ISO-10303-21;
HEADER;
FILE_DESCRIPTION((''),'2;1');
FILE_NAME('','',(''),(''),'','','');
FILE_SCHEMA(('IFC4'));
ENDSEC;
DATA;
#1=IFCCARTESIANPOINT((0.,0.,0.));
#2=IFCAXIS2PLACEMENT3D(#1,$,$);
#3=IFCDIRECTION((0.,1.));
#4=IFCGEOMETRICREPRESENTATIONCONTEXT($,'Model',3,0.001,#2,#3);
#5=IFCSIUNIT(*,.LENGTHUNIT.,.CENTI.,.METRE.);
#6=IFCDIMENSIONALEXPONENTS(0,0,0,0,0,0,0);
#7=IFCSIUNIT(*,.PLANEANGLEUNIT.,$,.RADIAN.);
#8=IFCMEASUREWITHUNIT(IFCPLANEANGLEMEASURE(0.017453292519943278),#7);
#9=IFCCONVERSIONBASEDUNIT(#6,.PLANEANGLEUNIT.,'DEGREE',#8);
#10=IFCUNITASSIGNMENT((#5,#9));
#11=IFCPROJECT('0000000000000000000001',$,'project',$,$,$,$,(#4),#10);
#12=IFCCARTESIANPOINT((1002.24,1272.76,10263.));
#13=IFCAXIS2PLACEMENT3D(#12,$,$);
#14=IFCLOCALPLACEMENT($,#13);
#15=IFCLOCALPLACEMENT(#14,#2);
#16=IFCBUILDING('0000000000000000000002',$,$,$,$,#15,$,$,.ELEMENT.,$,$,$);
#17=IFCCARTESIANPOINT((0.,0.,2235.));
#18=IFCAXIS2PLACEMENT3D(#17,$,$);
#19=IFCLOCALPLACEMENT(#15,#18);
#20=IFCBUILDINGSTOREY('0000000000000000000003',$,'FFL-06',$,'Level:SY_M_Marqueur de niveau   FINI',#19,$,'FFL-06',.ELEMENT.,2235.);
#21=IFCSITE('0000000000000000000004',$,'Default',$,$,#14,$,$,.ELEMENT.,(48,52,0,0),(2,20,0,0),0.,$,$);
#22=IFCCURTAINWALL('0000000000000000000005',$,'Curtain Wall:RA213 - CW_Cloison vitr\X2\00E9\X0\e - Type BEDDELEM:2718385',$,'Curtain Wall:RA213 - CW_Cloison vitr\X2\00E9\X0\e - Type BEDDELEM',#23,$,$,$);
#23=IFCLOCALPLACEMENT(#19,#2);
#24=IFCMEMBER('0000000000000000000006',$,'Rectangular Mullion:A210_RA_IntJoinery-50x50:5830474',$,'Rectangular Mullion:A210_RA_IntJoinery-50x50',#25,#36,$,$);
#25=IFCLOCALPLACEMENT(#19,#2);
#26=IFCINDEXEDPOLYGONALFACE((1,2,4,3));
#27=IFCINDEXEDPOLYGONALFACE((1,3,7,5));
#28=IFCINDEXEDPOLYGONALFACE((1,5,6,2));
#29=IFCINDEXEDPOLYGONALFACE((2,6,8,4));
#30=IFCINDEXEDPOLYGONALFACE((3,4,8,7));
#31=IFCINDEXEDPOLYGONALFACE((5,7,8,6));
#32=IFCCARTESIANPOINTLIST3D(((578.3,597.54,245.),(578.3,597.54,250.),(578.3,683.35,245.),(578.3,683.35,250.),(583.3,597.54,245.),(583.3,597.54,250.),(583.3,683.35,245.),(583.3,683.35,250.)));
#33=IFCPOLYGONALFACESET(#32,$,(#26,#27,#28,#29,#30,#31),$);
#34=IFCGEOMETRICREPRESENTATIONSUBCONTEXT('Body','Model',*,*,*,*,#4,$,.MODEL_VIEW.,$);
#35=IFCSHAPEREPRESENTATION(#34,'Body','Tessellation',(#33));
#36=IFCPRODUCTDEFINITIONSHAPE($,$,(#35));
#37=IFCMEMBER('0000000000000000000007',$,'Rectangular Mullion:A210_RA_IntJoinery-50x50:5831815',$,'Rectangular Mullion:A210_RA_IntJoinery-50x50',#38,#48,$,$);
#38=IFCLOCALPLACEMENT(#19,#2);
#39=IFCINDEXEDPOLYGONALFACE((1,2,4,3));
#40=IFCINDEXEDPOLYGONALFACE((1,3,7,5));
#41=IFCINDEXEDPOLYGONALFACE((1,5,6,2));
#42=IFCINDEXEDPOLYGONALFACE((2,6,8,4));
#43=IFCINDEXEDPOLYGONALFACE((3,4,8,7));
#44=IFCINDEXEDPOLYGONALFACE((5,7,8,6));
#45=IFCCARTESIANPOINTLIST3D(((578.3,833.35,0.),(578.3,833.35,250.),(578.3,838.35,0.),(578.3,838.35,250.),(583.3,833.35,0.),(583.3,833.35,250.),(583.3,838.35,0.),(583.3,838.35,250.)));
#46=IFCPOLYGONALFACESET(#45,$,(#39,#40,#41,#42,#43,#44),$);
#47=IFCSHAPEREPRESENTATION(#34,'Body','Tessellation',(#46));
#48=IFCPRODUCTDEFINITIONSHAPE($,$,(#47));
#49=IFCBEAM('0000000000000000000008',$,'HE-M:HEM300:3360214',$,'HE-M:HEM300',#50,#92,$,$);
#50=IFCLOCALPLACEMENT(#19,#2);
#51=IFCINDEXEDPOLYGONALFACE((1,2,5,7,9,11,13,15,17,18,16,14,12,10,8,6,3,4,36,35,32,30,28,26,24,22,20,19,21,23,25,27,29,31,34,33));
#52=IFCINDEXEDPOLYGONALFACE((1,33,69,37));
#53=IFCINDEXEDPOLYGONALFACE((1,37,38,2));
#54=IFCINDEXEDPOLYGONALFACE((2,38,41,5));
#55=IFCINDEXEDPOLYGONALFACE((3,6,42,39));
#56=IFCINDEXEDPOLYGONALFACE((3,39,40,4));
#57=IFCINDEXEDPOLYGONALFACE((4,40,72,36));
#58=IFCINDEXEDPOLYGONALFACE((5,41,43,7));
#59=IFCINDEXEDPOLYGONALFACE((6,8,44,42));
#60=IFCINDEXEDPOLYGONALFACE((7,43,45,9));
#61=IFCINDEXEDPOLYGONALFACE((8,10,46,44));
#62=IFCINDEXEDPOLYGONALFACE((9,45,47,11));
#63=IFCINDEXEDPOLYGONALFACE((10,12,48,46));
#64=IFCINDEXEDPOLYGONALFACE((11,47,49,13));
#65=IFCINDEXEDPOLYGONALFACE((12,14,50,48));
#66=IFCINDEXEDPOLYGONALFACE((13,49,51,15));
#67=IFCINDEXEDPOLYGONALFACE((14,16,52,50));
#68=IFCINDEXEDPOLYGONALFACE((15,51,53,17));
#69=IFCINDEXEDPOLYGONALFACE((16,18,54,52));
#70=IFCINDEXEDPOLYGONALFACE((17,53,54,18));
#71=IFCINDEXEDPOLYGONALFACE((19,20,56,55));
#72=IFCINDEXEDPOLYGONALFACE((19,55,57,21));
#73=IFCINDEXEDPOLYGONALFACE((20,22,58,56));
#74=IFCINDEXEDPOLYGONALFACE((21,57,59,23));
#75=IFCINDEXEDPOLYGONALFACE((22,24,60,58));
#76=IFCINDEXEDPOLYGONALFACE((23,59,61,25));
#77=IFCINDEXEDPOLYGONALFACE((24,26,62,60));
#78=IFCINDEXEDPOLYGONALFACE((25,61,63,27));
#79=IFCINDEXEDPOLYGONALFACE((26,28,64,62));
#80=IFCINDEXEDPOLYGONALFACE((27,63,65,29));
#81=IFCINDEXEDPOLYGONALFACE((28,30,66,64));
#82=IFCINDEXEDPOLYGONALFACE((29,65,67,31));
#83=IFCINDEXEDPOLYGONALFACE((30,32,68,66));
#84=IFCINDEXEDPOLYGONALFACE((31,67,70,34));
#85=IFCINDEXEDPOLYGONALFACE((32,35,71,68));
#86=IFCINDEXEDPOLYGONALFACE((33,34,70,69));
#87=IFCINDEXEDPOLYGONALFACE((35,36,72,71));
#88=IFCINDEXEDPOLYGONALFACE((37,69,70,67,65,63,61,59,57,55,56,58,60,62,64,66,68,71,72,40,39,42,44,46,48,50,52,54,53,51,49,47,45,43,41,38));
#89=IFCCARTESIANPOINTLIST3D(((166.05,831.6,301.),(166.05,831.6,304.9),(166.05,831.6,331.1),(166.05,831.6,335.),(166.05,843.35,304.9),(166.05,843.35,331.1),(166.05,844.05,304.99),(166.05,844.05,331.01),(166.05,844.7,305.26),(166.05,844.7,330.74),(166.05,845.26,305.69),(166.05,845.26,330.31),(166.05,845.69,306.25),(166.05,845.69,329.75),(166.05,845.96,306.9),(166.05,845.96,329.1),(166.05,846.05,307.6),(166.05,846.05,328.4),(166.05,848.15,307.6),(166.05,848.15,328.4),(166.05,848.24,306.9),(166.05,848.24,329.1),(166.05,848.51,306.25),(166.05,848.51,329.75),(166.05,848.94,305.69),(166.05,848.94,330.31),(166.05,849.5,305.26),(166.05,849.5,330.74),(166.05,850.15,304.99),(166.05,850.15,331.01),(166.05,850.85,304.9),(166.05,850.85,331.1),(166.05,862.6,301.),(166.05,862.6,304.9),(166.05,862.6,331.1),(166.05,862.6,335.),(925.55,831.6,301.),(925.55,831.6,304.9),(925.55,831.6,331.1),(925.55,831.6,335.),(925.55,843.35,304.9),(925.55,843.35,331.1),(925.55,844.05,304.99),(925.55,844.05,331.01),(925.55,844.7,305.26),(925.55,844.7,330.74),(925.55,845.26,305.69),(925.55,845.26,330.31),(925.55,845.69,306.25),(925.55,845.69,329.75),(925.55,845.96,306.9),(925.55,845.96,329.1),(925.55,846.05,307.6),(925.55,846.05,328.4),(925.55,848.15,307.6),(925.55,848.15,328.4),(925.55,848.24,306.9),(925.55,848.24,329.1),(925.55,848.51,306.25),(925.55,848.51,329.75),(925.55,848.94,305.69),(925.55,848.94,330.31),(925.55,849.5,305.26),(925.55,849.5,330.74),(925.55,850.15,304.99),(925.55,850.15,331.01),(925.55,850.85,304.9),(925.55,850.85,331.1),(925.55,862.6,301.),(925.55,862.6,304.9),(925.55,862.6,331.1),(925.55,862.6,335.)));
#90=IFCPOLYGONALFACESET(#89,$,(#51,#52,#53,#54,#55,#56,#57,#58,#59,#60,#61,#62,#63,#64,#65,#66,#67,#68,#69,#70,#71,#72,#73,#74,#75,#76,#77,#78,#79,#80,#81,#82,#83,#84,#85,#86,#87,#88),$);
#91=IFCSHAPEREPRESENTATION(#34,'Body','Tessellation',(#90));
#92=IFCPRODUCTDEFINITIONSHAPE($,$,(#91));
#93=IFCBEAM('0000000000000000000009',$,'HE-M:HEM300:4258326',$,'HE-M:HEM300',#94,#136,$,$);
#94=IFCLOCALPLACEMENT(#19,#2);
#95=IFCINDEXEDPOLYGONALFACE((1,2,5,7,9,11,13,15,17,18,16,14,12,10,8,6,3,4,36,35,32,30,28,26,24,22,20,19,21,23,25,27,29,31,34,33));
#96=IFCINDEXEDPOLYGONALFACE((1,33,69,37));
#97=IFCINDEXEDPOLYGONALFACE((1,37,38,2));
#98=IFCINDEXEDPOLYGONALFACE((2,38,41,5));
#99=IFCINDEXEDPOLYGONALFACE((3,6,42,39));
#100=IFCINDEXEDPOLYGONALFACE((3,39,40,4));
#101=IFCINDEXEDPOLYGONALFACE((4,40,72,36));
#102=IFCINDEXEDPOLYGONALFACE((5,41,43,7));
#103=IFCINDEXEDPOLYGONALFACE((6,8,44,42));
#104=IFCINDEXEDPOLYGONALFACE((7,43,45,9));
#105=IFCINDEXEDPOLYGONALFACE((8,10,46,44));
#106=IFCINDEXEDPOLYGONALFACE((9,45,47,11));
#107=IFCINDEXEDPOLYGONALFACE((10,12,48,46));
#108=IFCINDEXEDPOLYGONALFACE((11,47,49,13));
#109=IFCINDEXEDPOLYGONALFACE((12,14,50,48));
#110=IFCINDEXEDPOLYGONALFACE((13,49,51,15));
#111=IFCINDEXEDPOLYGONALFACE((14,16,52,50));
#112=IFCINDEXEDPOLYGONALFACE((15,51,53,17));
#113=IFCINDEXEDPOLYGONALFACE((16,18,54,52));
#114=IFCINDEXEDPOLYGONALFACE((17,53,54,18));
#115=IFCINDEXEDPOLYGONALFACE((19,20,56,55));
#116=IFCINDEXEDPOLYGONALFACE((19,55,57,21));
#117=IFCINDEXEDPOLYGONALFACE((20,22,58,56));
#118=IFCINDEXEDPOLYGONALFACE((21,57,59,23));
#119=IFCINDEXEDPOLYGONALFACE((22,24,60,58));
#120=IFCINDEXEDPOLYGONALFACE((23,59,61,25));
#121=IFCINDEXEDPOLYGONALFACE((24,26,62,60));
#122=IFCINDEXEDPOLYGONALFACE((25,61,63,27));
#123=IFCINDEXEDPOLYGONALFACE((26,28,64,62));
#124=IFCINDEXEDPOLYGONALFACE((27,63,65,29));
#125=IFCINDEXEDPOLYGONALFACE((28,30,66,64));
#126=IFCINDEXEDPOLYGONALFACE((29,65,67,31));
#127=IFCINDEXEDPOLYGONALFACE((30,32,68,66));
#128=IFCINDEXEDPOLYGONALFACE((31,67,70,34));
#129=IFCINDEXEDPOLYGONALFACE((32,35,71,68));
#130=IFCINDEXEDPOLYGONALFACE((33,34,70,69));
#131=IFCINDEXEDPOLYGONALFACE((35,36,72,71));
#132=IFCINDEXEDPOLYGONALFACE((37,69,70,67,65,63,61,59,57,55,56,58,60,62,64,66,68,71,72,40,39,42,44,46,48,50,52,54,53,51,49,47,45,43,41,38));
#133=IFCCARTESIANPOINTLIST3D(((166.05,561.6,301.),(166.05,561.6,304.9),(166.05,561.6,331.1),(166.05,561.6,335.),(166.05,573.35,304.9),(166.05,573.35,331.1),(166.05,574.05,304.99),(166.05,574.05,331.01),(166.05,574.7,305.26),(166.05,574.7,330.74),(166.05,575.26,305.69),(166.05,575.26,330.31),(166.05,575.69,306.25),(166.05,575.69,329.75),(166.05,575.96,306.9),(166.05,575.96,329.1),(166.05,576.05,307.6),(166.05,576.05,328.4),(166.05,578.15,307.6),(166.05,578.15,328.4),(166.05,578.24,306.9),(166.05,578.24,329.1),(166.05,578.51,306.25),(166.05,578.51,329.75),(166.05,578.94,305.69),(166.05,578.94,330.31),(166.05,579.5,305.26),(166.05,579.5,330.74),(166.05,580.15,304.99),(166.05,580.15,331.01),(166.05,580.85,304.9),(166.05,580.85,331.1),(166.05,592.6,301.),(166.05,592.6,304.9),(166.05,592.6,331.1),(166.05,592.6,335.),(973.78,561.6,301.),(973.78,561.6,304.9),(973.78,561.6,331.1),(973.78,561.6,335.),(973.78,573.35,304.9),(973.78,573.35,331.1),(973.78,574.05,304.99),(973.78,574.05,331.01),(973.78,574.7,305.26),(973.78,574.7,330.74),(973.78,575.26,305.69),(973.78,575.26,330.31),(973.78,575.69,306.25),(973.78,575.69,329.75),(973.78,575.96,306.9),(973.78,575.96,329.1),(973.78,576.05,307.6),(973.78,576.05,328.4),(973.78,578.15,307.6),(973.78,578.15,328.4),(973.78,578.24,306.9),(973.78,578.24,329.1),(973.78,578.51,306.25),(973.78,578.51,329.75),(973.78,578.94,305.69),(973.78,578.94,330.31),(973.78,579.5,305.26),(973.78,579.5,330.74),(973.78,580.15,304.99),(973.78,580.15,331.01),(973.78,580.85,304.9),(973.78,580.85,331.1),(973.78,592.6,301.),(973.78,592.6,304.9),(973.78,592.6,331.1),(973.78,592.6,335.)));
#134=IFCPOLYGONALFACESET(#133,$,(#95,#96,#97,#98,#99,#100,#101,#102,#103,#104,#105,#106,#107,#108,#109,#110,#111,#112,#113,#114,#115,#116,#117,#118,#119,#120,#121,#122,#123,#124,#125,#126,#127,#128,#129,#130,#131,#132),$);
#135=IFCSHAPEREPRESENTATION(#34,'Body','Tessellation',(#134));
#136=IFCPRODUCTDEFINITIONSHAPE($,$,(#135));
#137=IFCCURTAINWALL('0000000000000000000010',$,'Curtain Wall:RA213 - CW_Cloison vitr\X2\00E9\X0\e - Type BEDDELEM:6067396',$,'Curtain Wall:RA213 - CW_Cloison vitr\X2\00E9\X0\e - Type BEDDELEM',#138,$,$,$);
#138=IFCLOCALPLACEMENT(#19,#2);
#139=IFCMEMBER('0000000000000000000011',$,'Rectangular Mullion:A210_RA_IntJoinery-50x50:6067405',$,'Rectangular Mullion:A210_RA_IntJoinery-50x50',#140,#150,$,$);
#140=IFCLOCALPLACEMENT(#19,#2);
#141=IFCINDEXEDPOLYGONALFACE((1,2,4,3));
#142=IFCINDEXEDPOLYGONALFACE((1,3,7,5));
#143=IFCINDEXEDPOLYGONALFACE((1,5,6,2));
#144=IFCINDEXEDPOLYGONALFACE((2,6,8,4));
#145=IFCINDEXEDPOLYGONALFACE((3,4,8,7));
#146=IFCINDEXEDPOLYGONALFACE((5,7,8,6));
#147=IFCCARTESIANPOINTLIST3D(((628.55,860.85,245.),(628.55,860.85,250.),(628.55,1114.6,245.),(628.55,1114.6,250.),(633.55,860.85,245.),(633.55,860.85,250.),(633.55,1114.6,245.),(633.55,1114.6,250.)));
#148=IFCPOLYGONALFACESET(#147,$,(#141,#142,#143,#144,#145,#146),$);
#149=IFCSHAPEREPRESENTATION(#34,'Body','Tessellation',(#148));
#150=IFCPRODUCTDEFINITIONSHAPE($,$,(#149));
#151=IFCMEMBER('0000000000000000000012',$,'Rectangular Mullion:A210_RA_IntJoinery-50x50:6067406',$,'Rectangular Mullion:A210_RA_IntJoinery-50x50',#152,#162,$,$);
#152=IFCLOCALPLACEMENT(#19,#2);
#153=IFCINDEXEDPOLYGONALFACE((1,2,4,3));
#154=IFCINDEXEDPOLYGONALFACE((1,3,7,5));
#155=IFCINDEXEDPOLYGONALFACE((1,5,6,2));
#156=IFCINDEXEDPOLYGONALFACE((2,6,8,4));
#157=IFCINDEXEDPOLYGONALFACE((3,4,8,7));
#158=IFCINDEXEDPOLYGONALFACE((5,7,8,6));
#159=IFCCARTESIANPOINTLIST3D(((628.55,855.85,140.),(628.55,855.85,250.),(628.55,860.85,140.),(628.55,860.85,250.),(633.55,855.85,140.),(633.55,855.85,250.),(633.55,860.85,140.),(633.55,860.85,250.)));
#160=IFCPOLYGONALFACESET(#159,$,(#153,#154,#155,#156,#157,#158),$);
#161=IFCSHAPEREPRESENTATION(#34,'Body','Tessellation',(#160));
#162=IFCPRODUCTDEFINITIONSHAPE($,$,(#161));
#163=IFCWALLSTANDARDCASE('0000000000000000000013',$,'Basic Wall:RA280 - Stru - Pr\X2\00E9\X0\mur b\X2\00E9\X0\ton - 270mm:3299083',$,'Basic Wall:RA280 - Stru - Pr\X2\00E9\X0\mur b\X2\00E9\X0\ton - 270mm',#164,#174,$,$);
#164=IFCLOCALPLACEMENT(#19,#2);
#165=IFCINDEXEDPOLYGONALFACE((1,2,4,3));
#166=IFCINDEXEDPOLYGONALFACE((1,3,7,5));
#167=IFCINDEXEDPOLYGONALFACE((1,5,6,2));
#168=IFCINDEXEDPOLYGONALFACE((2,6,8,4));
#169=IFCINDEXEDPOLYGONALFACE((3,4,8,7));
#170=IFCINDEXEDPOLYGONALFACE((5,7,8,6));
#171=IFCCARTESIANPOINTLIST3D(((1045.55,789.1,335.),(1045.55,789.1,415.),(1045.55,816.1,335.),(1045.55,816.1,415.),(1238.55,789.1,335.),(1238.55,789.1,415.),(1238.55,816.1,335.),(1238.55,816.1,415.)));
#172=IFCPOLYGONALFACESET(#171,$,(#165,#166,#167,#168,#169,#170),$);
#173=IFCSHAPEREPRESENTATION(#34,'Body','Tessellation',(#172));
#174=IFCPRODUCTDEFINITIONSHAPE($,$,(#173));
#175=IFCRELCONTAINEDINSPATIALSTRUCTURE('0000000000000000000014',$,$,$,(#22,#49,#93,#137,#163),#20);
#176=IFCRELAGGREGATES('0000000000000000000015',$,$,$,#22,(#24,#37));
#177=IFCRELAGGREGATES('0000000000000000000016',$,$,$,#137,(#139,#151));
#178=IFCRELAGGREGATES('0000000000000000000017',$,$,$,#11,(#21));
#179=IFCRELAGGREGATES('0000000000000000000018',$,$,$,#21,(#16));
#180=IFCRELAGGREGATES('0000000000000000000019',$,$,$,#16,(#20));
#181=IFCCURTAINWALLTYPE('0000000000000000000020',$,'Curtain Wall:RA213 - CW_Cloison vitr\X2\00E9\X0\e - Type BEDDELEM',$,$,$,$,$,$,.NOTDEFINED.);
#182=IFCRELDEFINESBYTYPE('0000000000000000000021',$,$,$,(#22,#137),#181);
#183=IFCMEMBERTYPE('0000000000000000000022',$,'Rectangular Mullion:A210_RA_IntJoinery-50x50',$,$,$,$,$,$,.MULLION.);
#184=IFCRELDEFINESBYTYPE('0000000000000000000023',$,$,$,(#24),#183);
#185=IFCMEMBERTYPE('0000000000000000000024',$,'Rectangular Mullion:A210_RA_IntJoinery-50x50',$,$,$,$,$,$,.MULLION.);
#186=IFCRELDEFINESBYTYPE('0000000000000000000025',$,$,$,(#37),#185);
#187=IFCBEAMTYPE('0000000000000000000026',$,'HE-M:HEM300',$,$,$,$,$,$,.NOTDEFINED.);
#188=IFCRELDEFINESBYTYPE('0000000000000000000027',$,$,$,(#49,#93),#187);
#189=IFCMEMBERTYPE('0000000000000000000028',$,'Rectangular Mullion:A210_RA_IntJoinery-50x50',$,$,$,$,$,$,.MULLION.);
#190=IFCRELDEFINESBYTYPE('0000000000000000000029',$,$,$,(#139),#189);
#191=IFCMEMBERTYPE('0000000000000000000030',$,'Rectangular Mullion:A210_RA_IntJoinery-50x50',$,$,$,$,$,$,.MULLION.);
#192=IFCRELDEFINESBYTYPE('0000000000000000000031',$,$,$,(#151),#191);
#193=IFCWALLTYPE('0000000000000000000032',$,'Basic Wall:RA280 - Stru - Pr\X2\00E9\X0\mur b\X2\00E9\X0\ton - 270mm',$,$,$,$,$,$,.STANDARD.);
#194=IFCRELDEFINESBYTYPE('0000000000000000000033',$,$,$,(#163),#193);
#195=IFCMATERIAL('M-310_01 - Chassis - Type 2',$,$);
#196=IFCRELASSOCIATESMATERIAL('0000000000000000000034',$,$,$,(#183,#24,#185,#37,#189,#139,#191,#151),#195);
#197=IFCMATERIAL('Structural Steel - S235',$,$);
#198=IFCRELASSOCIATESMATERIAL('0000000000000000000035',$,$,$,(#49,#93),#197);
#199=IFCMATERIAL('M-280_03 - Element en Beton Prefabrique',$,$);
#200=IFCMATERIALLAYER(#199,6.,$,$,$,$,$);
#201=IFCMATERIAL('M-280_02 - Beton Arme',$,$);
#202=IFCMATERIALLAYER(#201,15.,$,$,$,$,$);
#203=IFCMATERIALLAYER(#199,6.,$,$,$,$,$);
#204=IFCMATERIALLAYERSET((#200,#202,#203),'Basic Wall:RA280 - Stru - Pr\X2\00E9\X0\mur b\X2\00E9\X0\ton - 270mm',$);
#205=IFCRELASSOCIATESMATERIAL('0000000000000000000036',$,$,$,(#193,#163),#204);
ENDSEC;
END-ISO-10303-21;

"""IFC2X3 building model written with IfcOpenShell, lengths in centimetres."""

from ifc_helpers import new_model, entity, si_unit, converted_unit, direction, frame, frame_2d, origin, origin_2d_with_axis, place, context, subcontext, project, spatial, polyline, rectangle, i_section, extrude, clip, bounded_halfspace, source, transform, mapped, material, layer, layer_set, layer_usage, type_object, type_shapes, element, aggregate, save


model = new_model("IFC2X3")

# Units and contexts
model_context = context("Model", 3, precision=0.001, world=origin(), true_north=direction((0.0, 1.0)))
body_context = subcontext(model_context, "Body", "Model", "MODEL_VIEW")
ifc_project = project(units=[si_unit("LENGTHUNIT", "METRE", prefix="CENTI"), converted_unit("PLANEANGLEUNIT", "DEGREE", entity("IfcPlaneAngleMeasure", 0.017453292519943278), si_unit("PLANEANGLEUNIT", "RADIAN"), dimensions=[0, 0, 0, 0, 0, 0, 0])], contexts=[model_context])

# Site, building, storey
site_placement = place(None, frame((1002.24, 1272.76, 10263.0)))
site = spatial("IfcSite", under=ifc_project, at=site_placement, Name="Default", CompositionType="ELEMENT", RefLatitude=(48, 52, 0, 0), RefLongitude=(2, 20, 0, 0), RefElevation=0.0)
building_placement = place(site_placement, origin())
building = spatial("IfcBuilding", under=site, at=building_placement, CompositionType="ELEMENT")
storey_placement = place(building_placement, frame((0.0, 0.0, 2235.0)))
storey = spatial("IfcBuildingStorey", under=building, at=storey_placement, Name="FFL-06", ObjectType="Level:SY_M_Marqueur de niveau   FINI", LongName="FFL-06", CompositionType="ELEMENT", Elevation=2235.0)

# Curtain wall, members
curtain_wall_type_1 = type_object("IfcCurtainWallType", Name="Curtain Wall:RA213 - CW_Cloison vitrée - Type BEDDELEM", PredefinedType="NOTDEFINED")
curtain_wall_1_placement = place(storey_placement, frame((0.0, 0.0, -2235.0)))
curtain_wall_1 = element("IfcCurtainWall", 1, at=curtain_wall_1_placement, inside=storey, type_object=curtain_wall_type_1, Name="Curtain Wall:RA213 - CW_Cloison vitrée - Type BEDDELEM:2718385", ObjectType="Curtain Wall:RA213 - CW_Cloison vitrée - Type BEDDELEM")
ifc_material_1 = material(Name="M-310_01 - Chassis - Type 2")
member_type_1 = type_object("IfcMemberType", Name="Rectangular Mullion:A210_RA_IntJoinery-50x50", PredefinedType="MULLION", material=ifc_material_1)
shared_shape_1 = source(origin(), body_context, "Body", "SweptSolid", [
    extrude(rectangle(XDim=5.0, YDim=5.0, at=origin_2d_with_axis()), frame((-2.5, -2.5, -85.81), z_axis=(0.0, 0.0, 1.0), x_axis=(-1.0, 0.0, 0.0)), (0.0, 0.0, 1.0), 85.81),
])
type_shapes(member_type_1, [shared_shape_1])
member_1_placement = place(curtain_wall_1_placement, frame((578.3, 597.54, 2485.0), z_axis=(0.0, -1.0, 0.0), x_axis=(0.0, 0.0, 1.0)))
member_1 = element("IfcMember", 2, at=member_1_placement, type_object=member_type_1, material=ifc_material_1, Name="Rectangular Mullion:A210_RA_IntJoinery-50x50:5830474", ObjectType="Rectangular Mullion:A210_RA_IntJoinery-50x50", context=body_context, shape_type="MappedRepresentation", body=[
    mapped(shared_shape_1, transform((0.0, 0.0, 0.0), scale=1.0)),
])
member_type_2 = type_object("IfcMemberType", Name="Rectangular Mullion:A210_RA_IntJoinery-50x50", PredefinedType="MULLION", material=ifc_material_1)
shared_shape_2 = source(origin(), body_context, "Body", "SweptSolid", [
    extrude(rectangle(XDim=5.0, YDim=5.0, at=origin_2d_with_axis()), frame((-2.5, -2.5, -250.0), z_axis=(0.0, 0.0, 1.0), x_axis=(-1.0, 0.0, 0.0)), (0.0, 0.0, 1.0), 250.0),
])
type_shapes(member_type_2, [shared_shape_2])
member_2_placement = place(curtain_wall_1_placement, frame((578.3, 838.35, 2485.0), z_axis=(0.0, 0.0, 1.0), x_axis=(0.0, 1.0, 0.0)))
member_2 = element("IfcMember", 3, at=member_2_placement, type_object=member_type_2, material=ifc_material_1, Name="Rectangular Mullion:A210_RA_IntJoinery-50x50:5831815", ObjectType="Rectangular Mullion:A210_RA_IntJoinery-50x50", context=body_context, shape_type="MappedRepresentation", body=[
    mapped(shared_shape_2, transform((0.0, 0.0, 0.0), scale=1.0)),
])
aggregate(curtain_wall_1, [member_1, member_2])

# Beams
ifc_material_2 = material(Name="Structural Steel - S235")
beam_type_1 = type_object("IfcBeamType", Name="HE-M:HEM300", PredefinedType="NOTDEFINED")
beam_1_placement = place(storey_placement, frame((166.05, 847.1, 335.0)))
element("IfcBeam", 4, at=beam_1_placement, inside=storey, type_object=beam_type_1, material=ifc_material_2, Name="HE-M:HEM300:3360214", ObjectType="HE-M:HEM300", context=body_context, shape_type="SweptSolid", body=[
    extrude(i_section(OverallWidth=31.0, OverallDepth=34.0, WebThickness=2.1, FlangeThickness=3.9, FilletRadius=2.7, at=frame_2d((0.0, 0.0), x_axis=(0.0, 1.0))), frame((0.0, 0.0, -17.0), z_axis=(1.0, 0.0, 0.0), x_axis=(0.0, 0.0, -1.0)), (0.0, 0.0, 1.0), 759.5),
])
beam_2_placement = place(storey_placement, frame((166.05, 577.1, 335.0)))
element("IfcBeam", 5, at=beam_2_placement, inside=storey, type_object=beam_type_1, material=ifc_material_2, Name="HE-M:HEM300:4258326", ObjectType="HE-M:HEM300", context=body_context, shape_type="SweptSolid", body=[
    extrude(i_section(OverallWidth=31.0, OverallDepth=34.0, WebThickness=2.1, FlangeThickness=3.9, FilletRadius=2.7, at=frame_2d((0.0, 0.0), x_axis=(0.0, 1.0))), frame((0.0, 0.0, -17.0), z_axis=(1.0, 0.0, 0.0), x_axis=(0.0, 0.0, -1.0)), (0.0, 0.0, 1.0), 807.73),
])

# Curtain wall, members
curtain_wall_2_placement = place(storey_placement, frame((0.0, 0.0, -2235.0)))
curtain_wall_2 = element("IfcCurtainWall", 6, at=curtain_wall_2_placement, inside=storey, type_object=curtain_wall_type_1, Name="Curtain Wall:RA213 - CW_Cloison vitrée - Type BEDDELEM:6067396", ObjectType="Curtain Wall:RA213 - CW_Cloison vitrée - Type BEDDELEM")
member_type_3 = type_object("IfcMemberType", Name="Rectangular Mullion:A210_RA_IntJoinery-50x50", PredefinedType="MULLION", material=ifc_material_1)
shared_shape_3 = source(origin(), body_context, "Body", "SweptSolid", [
    extrude(rectangle(XDim=5.0, YDim=5.0, at=origin_2d_with_axis()), frame((-2.5, -2.5, -253.75), z_axis=(0.0, 0.0, 1.0), x_axis=(-1.0, 0.0, 0.0)), (0.0, 0.0, 1.0), 253.75),
])
type_shapes(member_type_3, [shared_shape_3])
member_3_placement = place(curtain_wall_2_placement, frame((628.55, 860.85, 2485.0), z_axis=(0.0, -1.0, 0.0), x_axis=(0.0, 0.0, 1.0)))
member_3 = element("IfcMember", 7, at=member_3_placement, type_object=member_type_3, material=ifc_material_1, Name="Rectangular Mullion:A210_RA_IntJoinery-50x50:6067405", ObjectType="Rectangular Mullion:A210_RA_IntJoinery-50x50", context=body_context, shape_type="MappedRepresentation", body=[
    mapped(shared_shape_3, transform((0.0, 0.0, 0.0), scale=1.0)),
])
member_type_4 = type_object("IfcMemberType", Name="Rectangular Mullion:A210_RA_IntJoinery-50x50", PredefinedType="MULLION", material=ifc_material_1)
shared_shape_4 = source(origin(), body_context, "Body", "SweptSolid", [
    extrude(rectangle(XDim=5.0, YDim=5.0, at=origin_2d_with_axis()), frame((-2.5, -2.5, -110.0), z_axis=(0.0, 0.0, 1.0), x_axis=(-1.0, 0.0, 0.0)), (0.0, 0.0, 1.0), 110.0),
])
type_shapes(member_type_4, [shared_shape_4])
member_4_placement = place(curtain_wall_2_placement, frame((628.55, 855.85, 2375.0), z_axis=(0.0, 0.0, -1.0), x_axis=(0.0, -1.0, 0.0)))
member_4 = element("IfcMember", 8, at=member_4_placement, type_object=member_type_4, material=ifc_material_1, Name="Rectangular Mullion:A210_RA_IntJoinery-50x50:6067406", ObjectType="Rectangular Mullion:A210_RA_IntJoinery-50x50", context=body_context, shape_type="MappedRepresentation", body=[
    mapped(shared_shape_4, transform((0.0, 0.0, 0.0), scale=1.0)),
])
aggregate(curtain_wall_2, [member_3, member_4])

# Wall
ifc_material_3 = material(Name="M-280_03 - Element en Beton Prefabrique")
ifc_layer_1 = layer(ifc_material_3, 6.0)
ifc_material_4 = material(Name="M-280_02 - Beton Arme")
ifc_layer_2 = layer(ifc_material_4, 15.0)
ifc_layer_3 = layer(ifc_material_3, 6.0)
ifc_layer_set_1 = layer_set([ifc_layer_1, ifc_layer_2, ifc_layer_3], Name="Basic Wall:RA280 - Stru - Prémur béton - 270mm")
ifc_layer_usage_1 = layer_usage(ifc_layer_set_1, "AXIS2", "NEGATIVE", 13.5)
wall_type_1 = type_object("IfcWallType", Name="Basic Wall:RA280 - Stru - Prémur béton - 270mm", PredefinedType="STANDARD", material=ifc_layer_set_1)
wall_1_placement = place(storey_placement, frame((1045.55, 802.6, 335.0)))
element("IfcWallStandardCase", 9, at=wall_1_placement, inside=storey, type_object=wall_type_1, material=ifc_layer_usage_1, Name="Basic Wall:RA280 - Stru - Prémur béton - 270mm:3299083", ObjectType="Basic Wall:RA280 - Stru - Prémur béton - 270mm", context=body_context, shape_type="Clipping", body=[
    clip(clip(extrude(rectangle(XDim=193.0, YDim=27.0, at=frame_2d((96.5, 0.0), x_axis=(-1.0, 0.0))), origin(), (0.0, 0.0, 1.0), 80.0), bounded_halfspace(frame((0.0, -13.5, 80.0), z_axis=(0.0, 0.0, -1.0), x_axis=(0.0, -1.0, 0.0)), True, frame((0.0, -13.5, 80.0)), polyline([(0.0, 0.0), (193.0, 0.0), (193.0, 27.0), (173.0, 27.0), (0.0, 27.0), (0.0, 0.0)]))), bounded_halfspace(frame((193.0, -13.5, 0.0), z_axis=(0.0, 0.0, 1.0), x_axis=(-1.0, 0.0, 0.0)), True, frame((193.0, -13.5, 0.0), z_axis=(0.0, 0.0, 1.0), x_axis=(-1.0, 0.0, 0.0)), polyline([(0.0, 0.0), (0.0, -27.0), (20.0, -27.0), (193.0, -27.0), (193.0, 0.0), (0.0, 0.0)]))),
])

save(model, "model.ifc")
